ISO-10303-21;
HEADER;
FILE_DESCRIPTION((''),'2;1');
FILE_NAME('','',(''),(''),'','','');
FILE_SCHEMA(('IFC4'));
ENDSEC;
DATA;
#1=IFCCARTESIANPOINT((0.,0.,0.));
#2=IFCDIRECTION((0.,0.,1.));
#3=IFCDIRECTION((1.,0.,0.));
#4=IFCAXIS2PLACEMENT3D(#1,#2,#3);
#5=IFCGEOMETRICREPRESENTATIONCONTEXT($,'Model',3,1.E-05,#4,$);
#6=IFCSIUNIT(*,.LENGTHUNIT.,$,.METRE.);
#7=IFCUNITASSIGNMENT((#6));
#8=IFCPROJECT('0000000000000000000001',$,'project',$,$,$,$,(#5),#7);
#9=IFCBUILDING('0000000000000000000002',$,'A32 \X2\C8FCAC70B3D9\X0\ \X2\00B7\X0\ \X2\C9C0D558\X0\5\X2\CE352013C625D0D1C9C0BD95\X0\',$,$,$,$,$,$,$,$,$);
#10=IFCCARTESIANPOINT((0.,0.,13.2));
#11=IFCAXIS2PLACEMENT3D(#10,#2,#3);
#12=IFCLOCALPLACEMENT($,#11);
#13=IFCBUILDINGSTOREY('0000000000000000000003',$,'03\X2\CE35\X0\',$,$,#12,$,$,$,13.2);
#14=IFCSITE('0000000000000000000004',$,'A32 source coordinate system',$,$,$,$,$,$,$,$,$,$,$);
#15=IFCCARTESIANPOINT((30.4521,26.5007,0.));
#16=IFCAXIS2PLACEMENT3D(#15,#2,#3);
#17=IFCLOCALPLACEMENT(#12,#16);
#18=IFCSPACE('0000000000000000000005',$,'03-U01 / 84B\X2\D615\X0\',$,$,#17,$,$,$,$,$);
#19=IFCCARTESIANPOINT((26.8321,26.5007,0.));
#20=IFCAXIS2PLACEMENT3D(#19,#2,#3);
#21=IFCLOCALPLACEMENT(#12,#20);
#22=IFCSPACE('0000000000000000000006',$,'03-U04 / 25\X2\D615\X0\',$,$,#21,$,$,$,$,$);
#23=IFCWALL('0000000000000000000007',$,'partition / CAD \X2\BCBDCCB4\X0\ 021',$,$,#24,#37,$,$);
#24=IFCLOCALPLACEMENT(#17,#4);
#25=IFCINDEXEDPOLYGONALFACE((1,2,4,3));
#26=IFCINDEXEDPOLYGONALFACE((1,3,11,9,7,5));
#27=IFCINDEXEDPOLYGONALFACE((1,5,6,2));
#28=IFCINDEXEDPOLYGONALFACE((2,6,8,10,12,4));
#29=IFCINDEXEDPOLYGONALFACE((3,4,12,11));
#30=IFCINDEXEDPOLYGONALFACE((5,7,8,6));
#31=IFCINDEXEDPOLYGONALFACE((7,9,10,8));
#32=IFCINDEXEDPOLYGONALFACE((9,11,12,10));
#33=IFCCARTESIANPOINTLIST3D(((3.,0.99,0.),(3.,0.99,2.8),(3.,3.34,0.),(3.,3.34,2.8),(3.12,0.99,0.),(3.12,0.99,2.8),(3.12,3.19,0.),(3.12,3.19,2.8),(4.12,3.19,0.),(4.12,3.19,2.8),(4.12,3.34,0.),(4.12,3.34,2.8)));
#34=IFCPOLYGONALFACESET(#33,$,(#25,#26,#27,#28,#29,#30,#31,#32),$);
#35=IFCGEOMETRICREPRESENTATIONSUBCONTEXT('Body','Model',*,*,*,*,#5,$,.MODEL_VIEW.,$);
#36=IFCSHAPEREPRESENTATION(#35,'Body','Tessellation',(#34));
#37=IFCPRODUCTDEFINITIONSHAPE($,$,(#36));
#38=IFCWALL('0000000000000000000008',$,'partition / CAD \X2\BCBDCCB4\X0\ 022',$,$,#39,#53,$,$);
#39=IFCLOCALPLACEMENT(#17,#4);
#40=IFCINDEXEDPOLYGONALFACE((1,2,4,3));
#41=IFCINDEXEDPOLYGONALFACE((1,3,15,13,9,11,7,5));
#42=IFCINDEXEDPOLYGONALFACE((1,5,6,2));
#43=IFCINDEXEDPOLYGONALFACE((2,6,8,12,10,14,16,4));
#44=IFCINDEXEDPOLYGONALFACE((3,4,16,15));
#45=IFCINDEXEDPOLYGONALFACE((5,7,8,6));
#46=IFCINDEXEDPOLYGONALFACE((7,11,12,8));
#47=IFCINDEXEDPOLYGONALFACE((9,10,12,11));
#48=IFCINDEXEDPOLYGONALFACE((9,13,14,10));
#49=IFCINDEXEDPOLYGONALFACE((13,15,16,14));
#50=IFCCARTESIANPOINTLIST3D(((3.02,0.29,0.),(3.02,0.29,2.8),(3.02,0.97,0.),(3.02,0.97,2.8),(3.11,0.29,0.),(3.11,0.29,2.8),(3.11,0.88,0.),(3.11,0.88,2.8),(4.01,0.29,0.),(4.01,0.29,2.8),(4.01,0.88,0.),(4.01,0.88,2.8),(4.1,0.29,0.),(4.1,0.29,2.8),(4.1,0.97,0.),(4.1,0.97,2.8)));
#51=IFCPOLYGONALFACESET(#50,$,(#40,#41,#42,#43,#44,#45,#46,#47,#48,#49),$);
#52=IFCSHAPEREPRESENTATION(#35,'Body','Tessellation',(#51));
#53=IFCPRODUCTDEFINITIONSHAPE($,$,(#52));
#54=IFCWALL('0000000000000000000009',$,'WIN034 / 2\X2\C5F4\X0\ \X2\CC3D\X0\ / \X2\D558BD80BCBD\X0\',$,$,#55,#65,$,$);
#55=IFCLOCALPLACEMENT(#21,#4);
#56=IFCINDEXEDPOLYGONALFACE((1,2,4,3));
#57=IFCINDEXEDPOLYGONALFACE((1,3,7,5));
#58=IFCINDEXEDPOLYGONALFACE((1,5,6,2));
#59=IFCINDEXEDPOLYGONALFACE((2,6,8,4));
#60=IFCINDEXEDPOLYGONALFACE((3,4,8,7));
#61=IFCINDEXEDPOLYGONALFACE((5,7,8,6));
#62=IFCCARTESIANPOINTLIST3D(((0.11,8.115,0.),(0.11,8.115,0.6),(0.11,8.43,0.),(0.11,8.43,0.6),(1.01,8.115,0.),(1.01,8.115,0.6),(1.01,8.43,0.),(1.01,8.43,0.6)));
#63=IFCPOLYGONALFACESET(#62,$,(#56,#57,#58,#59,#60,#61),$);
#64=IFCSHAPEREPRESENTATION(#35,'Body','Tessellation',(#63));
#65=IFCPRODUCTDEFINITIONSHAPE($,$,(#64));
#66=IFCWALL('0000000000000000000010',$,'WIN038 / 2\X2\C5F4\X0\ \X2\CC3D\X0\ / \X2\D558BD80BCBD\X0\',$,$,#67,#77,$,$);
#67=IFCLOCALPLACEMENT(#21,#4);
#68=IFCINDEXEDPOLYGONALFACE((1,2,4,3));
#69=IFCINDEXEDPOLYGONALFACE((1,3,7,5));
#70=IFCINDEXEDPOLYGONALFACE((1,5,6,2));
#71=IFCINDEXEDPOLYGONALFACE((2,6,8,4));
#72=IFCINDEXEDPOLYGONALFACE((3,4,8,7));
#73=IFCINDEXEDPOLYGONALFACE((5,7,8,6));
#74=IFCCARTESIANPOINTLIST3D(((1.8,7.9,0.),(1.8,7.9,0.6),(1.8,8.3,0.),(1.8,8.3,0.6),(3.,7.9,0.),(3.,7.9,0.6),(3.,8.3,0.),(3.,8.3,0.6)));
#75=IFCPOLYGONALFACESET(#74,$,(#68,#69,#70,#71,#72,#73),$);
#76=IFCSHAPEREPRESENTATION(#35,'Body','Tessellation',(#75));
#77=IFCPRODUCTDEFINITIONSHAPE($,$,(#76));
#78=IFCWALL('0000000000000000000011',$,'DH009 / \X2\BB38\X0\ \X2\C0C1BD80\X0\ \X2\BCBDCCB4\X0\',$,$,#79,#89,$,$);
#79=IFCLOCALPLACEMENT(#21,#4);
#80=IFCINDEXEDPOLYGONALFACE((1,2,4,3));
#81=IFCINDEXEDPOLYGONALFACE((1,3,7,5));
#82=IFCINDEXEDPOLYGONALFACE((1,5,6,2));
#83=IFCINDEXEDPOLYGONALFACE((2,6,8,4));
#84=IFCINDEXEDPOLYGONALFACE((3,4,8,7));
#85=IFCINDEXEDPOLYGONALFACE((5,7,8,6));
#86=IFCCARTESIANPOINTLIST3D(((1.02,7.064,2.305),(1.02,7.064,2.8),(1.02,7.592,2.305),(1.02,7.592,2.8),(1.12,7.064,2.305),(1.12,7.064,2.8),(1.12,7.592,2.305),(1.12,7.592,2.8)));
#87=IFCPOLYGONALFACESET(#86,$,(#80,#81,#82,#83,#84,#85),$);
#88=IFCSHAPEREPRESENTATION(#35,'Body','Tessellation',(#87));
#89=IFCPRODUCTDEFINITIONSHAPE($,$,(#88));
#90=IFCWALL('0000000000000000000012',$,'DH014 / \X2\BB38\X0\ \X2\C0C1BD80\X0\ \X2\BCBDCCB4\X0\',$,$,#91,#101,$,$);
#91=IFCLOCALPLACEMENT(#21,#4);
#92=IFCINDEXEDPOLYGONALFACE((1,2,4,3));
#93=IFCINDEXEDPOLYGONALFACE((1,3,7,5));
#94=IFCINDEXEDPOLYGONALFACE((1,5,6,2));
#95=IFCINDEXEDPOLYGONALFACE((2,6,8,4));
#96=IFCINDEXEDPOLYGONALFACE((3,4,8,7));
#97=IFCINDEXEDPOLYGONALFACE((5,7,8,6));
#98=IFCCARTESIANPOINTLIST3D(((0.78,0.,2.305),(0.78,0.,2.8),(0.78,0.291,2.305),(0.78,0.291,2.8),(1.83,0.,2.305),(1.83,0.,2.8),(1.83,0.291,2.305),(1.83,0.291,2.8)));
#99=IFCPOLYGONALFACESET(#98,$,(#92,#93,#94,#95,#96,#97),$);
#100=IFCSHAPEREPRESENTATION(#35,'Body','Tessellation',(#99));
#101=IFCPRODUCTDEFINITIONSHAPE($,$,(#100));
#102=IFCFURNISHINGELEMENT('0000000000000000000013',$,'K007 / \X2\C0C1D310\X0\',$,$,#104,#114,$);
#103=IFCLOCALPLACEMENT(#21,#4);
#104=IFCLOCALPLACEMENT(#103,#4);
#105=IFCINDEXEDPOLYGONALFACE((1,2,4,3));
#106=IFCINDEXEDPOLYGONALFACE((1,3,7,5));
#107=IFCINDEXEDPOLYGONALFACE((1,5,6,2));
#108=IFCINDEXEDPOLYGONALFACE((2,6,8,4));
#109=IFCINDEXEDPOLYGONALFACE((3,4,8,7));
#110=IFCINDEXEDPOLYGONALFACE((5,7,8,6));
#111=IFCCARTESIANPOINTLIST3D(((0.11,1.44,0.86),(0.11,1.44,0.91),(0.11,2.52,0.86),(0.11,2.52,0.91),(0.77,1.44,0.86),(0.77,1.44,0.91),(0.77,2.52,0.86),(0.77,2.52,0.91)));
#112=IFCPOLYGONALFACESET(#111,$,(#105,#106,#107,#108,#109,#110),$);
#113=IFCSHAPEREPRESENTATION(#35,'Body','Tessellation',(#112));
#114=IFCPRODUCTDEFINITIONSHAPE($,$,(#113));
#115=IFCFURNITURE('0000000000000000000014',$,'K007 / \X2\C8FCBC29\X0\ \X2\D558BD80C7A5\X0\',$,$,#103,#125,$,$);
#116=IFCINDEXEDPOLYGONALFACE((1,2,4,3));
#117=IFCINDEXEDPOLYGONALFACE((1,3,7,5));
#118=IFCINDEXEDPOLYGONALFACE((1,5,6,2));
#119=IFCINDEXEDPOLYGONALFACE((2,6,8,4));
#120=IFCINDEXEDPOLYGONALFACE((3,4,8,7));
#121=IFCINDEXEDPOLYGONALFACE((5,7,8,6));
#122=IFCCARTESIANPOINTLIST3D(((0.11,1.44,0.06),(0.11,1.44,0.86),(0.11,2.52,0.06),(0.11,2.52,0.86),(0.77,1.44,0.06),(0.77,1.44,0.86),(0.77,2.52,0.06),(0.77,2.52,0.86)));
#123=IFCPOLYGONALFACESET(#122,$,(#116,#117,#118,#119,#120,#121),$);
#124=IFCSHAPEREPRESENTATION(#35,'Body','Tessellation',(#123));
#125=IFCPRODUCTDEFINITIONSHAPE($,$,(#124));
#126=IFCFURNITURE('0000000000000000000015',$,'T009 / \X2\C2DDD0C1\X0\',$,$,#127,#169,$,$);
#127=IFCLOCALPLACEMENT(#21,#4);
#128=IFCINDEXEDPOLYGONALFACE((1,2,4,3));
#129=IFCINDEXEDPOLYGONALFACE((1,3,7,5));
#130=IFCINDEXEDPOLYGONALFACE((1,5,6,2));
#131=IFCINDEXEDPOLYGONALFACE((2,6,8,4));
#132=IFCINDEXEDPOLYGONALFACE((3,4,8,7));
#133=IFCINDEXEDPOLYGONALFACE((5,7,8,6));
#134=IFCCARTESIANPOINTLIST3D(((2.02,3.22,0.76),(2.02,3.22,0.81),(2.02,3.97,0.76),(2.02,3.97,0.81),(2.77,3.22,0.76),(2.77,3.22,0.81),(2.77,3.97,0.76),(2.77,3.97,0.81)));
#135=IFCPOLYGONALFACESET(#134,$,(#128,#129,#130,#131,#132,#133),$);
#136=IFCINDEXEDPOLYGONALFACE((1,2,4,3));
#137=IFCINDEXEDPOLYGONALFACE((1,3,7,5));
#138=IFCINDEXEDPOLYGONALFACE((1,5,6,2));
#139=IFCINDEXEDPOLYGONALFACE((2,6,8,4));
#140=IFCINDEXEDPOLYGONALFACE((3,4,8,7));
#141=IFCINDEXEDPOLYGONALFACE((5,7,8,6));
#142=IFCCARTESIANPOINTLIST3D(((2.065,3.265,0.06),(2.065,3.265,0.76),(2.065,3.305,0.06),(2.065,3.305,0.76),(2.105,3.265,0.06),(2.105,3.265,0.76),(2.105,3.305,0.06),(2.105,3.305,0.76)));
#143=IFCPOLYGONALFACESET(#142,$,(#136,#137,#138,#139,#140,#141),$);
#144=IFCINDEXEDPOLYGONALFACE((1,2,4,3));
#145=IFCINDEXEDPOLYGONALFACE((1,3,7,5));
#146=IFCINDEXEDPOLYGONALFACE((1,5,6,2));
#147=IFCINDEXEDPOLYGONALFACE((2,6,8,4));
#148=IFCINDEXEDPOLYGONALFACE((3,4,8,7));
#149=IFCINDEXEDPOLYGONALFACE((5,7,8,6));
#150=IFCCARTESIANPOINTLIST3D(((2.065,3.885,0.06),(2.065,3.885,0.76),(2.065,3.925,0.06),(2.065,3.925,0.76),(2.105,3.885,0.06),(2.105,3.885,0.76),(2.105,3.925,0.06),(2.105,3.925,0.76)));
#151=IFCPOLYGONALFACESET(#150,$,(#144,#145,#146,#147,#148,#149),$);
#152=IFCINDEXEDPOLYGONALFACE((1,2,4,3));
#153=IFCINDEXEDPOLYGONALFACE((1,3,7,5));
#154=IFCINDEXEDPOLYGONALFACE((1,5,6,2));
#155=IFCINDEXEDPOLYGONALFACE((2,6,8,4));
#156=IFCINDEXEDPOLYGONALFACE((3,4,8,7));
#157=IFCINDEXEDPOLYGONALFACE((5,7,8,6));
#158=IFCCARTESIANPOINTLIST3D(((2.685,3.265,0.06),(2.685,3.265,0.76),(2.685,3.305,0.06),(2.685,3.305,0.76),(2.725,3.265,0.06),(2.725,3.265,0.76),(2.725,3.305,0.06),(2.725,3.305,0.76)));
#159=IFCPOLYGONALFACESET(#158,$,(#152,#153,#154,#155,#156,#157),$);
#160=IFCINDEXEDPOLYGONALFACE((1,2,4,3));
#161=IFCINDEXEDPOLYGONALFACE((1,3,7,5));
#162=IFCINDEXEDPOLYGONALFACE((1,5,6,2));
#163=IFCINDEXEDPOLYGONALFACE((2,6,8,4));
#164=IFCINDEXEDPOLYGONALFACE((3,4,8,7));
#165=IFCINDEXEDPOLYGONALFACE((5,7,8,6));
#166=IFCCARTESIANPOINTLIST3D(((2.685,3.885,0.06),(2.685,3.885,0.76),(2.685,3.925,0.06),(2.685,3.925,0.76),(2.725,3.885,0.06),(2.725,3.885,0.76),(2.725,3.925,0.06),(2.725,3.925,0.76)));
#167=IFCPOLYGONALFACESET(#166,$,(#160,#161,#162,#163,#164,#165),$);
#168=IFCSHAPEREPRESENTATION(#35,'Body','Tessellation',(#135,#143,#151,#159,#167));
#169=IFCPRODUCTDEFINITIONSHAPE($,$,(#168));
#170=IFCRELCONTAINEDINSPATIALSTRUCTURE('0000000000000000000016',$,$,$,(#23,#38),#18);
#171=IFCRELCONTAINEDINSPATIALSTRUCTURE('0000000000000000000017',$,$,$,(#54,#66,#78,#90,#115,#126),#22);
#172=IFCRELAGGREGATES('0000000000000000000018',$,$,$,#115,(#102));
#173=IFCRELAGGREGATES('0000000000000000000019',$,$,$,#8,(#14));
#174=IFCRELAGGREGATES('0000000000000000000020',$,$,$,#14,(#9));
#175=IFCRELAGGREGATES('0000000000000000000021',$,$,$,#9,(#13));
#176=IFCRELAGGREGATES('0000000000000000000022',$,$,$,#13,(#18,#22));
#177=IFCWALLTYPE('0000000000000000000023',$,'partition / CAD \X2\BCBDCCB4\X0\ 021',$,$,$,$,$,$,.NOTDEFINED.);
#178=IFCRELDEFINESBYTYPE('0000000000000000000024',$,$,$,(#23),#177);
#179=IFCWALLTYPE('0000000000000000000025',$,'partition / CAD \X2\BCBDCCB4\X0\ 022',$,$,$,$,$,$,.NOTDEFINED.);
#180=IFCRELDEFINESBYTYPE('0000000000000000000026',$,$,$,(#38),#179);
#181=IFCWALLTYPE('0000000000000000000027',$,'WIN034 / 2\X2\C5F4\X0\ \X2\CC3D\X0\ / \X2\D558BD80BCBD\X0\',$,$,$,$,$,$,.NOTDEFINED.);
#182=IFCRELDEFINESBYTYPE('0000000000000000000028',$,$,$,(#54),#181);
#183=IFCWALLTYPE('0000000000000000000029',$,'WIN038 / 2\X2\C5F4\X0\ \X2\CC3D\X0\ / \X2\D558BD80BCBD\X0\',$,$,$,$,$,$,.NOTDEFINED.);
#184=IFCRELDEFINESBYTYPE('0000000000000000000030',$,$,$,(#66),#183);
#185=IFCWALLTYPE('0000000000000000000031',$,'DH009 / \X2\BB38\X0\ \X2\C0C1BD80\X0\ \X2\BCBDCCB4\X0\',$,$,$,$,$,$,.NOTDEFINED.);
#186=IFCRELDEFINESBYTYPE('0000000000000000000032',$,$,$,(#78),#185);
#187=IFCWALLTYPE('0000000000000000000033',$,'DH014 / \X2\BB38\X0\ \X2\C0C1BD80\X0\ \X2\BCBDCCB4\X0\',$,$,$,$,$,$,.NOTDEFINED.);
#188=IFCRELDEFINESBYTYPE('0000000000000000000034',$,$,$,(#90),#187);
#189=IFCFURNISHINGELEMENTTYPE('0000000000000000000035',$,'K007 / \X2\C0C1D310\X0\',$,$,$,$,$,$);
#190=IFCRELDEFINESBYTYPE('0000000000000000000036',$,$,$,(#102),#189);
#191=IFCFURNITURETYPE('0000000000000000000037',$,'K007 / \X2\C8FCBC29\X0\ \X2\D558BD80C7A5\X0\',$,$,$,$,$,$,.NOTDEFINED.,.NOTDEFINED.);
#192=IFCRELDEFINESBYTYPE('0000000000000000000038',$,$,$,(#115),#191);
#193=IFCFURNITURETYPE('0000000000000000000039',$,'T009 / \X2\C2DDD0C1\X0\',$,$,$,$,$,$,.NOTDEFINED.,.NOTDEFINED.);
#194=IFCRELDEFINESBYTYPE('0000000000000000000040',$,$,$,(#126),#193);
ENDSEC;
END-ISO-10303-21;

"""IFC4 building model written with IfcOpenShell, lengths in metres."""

from ifc_helpers import new_model, si_unit, frame, origin, origin_with_axes, place, context, subcontext, project, spatial, polyline, outline, extrude, source, transform, mapped, type_object, type_shapes, element, aggregate, save


model = new_model("IFC4")

# Units and contexts
model_context = context("Model", 3, precision=1e-05, world=origin_with_axes())
body_context = subcontext(model_context, "Body", "Model", "MODEL_VIEW")
ifc_project = project(units=[si_unit("LENGTHUNIT", "METRE")], contexts=[model_context])

# Site, building, storey, space
storey_placement = place(None, frame((0.0, 0.0, 13.2), z_axis=(0.0, 0.0, 1.0), x_axis=(1.0, 0.0, 0.0)))
space_1_placement = place(storey_placement, frame((30.4521, 26.5007, 0.0), z_axis=(0.0, 0.0, 1.0), x_axis=(1.0, 0.0, 0.0)))
site = spatial("IfcSite", under=ifc_project, Name="A32 source coordinate system")
building = spatial("IfcBuilding", under=site, Name="A32 주거동 · 지하5층–옥탑지붕")
storey = spatial("IfcBuildingStorey", under=building, at=storey_placement, Name="03층", Elevation=13.2)
space_1 = spatial("IfcSpace", under=storey, at=space_1_placement, Name="03-U01 / 84B형")

# Walls
wall_type_1 = type_object("IfcWallType", Name="partition / CAD 벽체 021", PredefinedType="NOTDEFINED")
shared_shape_1 = source(origin(), body_context, "Body", "SweptSolid", [
    extrude(outline(polyline([(4.12, 3.34), (4.12, 3.19), (3.12, 3.19), (3.12, 0.99), (3.0, 0.99), (3.0, 3.34), (4.12, 3.34)])), origin(), (0.0, 0.0, 1.0), 2.8),
])
type_shapes(wall_type_1, [shared_shape_1])
wall_1_placement = place(space_1_placement, origin_with_axes())
element("IfcWall", 1, at=wall_1_placement, inside=space_1, type_object=wall_type_1, Name="partition / CAD 벽체 021", context=body_context, shape_type="MappedRepresentation", body=[
    mapped(shared_shape_1, transform((0.0, 0.0, 0.0), scale=1.0)),
])
wall_type_2 = type_object("IfcWallType", Name="partition / CAD 벽체 022", PredefinedType="NOTDEFINED")
shared_shape_2 = source(origin(), body_context, "Body", "SweptSolid", [
    extrude(outline(polyline([(4.1, 0.97), (4.1, 0.29), (4.01, 0.29), (4.01, 0.88), (3.11, 0.88), (3.11, 0.29), (3.02, 0.29), (3.02, 0.97), (4.1, 0.97)])), origin(), (0.0, 0.0, 1.0), 2.8),
])
type_shapes(wall_type_2, [shared_shape_2])
wall_2_placement = place(space_1_placement, origin_with_axes())
element("IfcWall", 2, at=wall_2_placement, inside=space_1, type_object=wall_type_2, Name="partition / CAD 벽체 022", context=body_context, shape_type="MappedRepresentation", body=[
    mapped(shared_shape_2, transform((0.0, 0.0, 0.0), scale=1.0)),
])

# Shared definitions
space_2_placement = place(storey_placement, frame((26.8321, 26.5007, 0.0), z_axis=(0.0, 0.0, 1.0), x_axis=(1.0, 0.0, 0.0)))
space_2 = spatial("IfcSpace", under=storey, at=space_2_placement, Name="03-U04 / 25형")

# Walls
wall_type_3 = type_object("IfcWallType", Name="WIN034 / 2열 창 / 하부벽", PredefinedType="NOTDEFINED")
shared_shape_3 = source(origin(), body_context, "Body", "SweptSolid", [
    extrude(outline(polyline([(0.11, 8.115), (0.11, 8.43), (1.01, 8.43), (1.01, 8.115), (0.11, 8.115)])), origin(), (0.0, 0.0, 1.0), 0.6),
])
type_shapes(wall_type_3, [shared_shape_3])
wall_3_placement = place(space_2_placement, origin_with_axes())
element("IfcWall", 3, at=wall_3_placement, inside=space_2, type_object=wall_type_3, Name="WIN034 / 2열 창 / 하부벽", context=body_context, shape_type="MappedRepresentation", body=[
    mapped(shared_shape_3, transform((0.0, 0.0, 0.0), scale=1.0)),
])
wall_type_4 = type_object("IfcWallType", Name="WIN038 / 2열 창 / 하부벽", PredefinedType="NOTDEFINED")
shared_shape_4 = source(origin(), body_context, "Body", "SweptSolid", [
    extrude(outline(polyline([(1.8, 7.9), (1.8, 8.3), (3.0, 8.3), (3.0, 7.9), (1.8, 7.9)])), origin(), (0.0, 0.0, 1.0), 0.6),
])
type_shapes(wall_type_4, [shared_shape_4])
wall_4_placement = place(space_2_placement, origin_with_axes())
element("IfcWall", 4, at=wall_4_placement, inside=space_2, type_object=wall_type_4, Name="WIN038 / 2열 창 / 하부벽", context=body_context, shape_type="MappedRepresentation", body=[
    mapped(shared_shape_4, transform((0.0, 0.0, 0.0), scale=1.0)),
])
wall_type_5 = type_object("IfcWallType", Name="DH009 / 문 상부 벽체", PredefinedType="NOTDEFINED")
shared_shape_5 = source(origin(), body_context, "Body", "SweptSolid", [
    extrude(outline(polyline([(1.02, 7.064), (1.02, 7.592), (1.12, 7.592), (1.12, 7.064), (1.02, 7.064)])), frame((0.0, 0.0, 2.305)), (0.0, 0.0, 1.0), 0.495),
])
type_shapes(wall_type_5, [shared_shape_5])
wall_5_placement = place(space_2_placement, origin_with_axes())
element("IfcWall", 5, at=wall_5_placement, inside=space_2, type_object=wall_type_5, Name="DH009 / 문 상부 벽체", context=body_context, shape_type="MappedRepresentation", body=[
    mapped(shared_shape_5, transform((0.0, 0.0, 0.0), scale=1.0)),
])
wall_type_6 = type_object("IfcWallType", Name="DH014 / 문 상부 벽체", PredefinedType="NOTDEFINED")
shared_shape_6 = source(origin(), body_context, "Body", "SweptSolid", [
    extrude(outline(polyline([(0.78, 0.291), (1.83, 0.291), (1.83, 0.0), (0.78, 0.0), (0.78, 0.291)])), frame((0.0, 0.0, 2.305)), (0.0, 0.0, 1.0), 0.495),
])
type_shapes(wall_type_6, [shared_shape_6])
wall_6_placement = place(space_2_placement, origin_with_axes())
element("IfcWall", 6, at=wall_6_placement, inside=space_2, type_object=wall_type_6, Name="DH014 / 문 상부 벽체", context=body_context, shape_type="MappedRepresentation", body=[
    mapped(shared_shape_6, transform((0.0, 0.0, 0.0), scale=1.0)),
])

# Furnishing element
furnishing_element_type_1 = type_object("IfcFurnishingElementType", Name="K007 / 상판")
shared_shape_7 = source(origin(), body_context, "Body", "SweptSolid", [
    extrude(outline(polyline([(0.77, 2.52), (0.77, 1.44), (0.11, 1.44), (0.11, 2.52), (0.77, 2.52)])), frame((0.0, 0.0, 0.86)), (0.0, 0.0, 1.0), 0.05),
])
type_shapes(furnishing_element_type_1, [shared_shape_7])
furniture_1_placement = place(space_2_placement, origin_with_axes())
furnishing_1_placement = place(furniture_1_placement, origin_with_axes())
furnishing_1 = element("IfcFurnishingElement", 7, at=furnishing_1_placement, type_object=furnishing_element_type_1, Name="K007 / 상판", context=body_context, shape_type="MappedRepresentation", body=[
    mapped(shared_shape_7, transform((0.0, 0.0, 0.0), scale=1.0)),
])

# Furniture
furniture_type_1 = type_object("IfcFurnitureType", Name="K007 / 주방 하부장", AssemblyPlace="NOTDEFINED", PredefinedType="NOTDEFINED")
shared_shape_8 = source(origin(), body_context, "Body", "SweptSolid", [
    extrude(outline(polyline([(0.11, 2.52), (0.77, 2.52), (0.77, 1.44), (0.11, 1.44), (0.11, 2.52)])), frame((0.0, 0.0, 0.06)), (0.0, 0.0, 1.0), 0.8),
])
type_shapes(furniture_type_1, [shared_shape_8])
furniture_1 = element("IfcFurniture", 8, at=furniture_1_placement, inside=space_2, type_object=furniture_type_1, Name="K007 / 주방 하부장", context=body_context, shape_type="MappedRepresentation", body=[
    mapped(shared_shape_8, transform((0.0, 0.0, 0.0), scale=1.0)),
])
aggregate(furniture_1, [furnishing_1])
furniture_type_2 = type_object("IfcFurnitureType", Name="T009 / 식탁", AssemblyPlace="NOTDEFINED", PredefinedType="NOTDEFINED")
shared_shape_9 = source(origin(), body_context, "Body", "SweptSolid", [
    extrude(outline(polyline([(2.77, 3.22), (2.02, 3.22), (2.02, 3.97), (2.77, 3.97), (2.77, 3.22)])), frame((0.0, 0.0, 0.76)), (0.0, 0.0, 1.0), 0.05),
    extrude(outline(polyline([(2.065, 3.265), (2.065, 3.305), (2.105, 3.305), (2.105, 3.265), (2.065, 3.265)])), frame((0.0, 0.0, 0.06)), (0.0, 0.0, 1.0), 0.7),
    extrude(outline(polyline([(2.065, 3.885), (2.065, 3.925), (2.105, 3.925), (2.105, 3.885), (2.065, 3.885)])), frame((0.0, 0.0, 0.06)), (0.0, 0.0, 1.0), 0.7),
    extrude(outline(polyline([(2.685, 3.265), (2.685, 3.305), (2.725, 3.305), (2.725, 3.265), (2.685, 3.265)])), frame((0.0, 0.0, 0.06)), (0.0, 0.0, 1.0), 0.7),
    extrude(outline(polyline([(2.685, 3.885), (2.685, 3.925), (2.725, 3.925), (2.725, 3.885), (2.685, 3.885)])), frame((0.0, 0.0, 0.06)), (0.0, 0.0, 1.0), 0.7),
])
type_shapes(furniture_type_2, [shared_shape_9])
furniture_2_placement = place(space_2_placement, origin_with_axes())
element("IfcFurniture", 9, at=furniture_2_placement, inside=space_2, type_object=furniture_type_2, Name="T009 / 식탁", context=body_context, shape_type="MappedRepresentation", body=[
    mapped(shared_shape_9, transform((0.0, 0.0, 0.0), scale=1.0)),
])

save(model, "model.ifc")
